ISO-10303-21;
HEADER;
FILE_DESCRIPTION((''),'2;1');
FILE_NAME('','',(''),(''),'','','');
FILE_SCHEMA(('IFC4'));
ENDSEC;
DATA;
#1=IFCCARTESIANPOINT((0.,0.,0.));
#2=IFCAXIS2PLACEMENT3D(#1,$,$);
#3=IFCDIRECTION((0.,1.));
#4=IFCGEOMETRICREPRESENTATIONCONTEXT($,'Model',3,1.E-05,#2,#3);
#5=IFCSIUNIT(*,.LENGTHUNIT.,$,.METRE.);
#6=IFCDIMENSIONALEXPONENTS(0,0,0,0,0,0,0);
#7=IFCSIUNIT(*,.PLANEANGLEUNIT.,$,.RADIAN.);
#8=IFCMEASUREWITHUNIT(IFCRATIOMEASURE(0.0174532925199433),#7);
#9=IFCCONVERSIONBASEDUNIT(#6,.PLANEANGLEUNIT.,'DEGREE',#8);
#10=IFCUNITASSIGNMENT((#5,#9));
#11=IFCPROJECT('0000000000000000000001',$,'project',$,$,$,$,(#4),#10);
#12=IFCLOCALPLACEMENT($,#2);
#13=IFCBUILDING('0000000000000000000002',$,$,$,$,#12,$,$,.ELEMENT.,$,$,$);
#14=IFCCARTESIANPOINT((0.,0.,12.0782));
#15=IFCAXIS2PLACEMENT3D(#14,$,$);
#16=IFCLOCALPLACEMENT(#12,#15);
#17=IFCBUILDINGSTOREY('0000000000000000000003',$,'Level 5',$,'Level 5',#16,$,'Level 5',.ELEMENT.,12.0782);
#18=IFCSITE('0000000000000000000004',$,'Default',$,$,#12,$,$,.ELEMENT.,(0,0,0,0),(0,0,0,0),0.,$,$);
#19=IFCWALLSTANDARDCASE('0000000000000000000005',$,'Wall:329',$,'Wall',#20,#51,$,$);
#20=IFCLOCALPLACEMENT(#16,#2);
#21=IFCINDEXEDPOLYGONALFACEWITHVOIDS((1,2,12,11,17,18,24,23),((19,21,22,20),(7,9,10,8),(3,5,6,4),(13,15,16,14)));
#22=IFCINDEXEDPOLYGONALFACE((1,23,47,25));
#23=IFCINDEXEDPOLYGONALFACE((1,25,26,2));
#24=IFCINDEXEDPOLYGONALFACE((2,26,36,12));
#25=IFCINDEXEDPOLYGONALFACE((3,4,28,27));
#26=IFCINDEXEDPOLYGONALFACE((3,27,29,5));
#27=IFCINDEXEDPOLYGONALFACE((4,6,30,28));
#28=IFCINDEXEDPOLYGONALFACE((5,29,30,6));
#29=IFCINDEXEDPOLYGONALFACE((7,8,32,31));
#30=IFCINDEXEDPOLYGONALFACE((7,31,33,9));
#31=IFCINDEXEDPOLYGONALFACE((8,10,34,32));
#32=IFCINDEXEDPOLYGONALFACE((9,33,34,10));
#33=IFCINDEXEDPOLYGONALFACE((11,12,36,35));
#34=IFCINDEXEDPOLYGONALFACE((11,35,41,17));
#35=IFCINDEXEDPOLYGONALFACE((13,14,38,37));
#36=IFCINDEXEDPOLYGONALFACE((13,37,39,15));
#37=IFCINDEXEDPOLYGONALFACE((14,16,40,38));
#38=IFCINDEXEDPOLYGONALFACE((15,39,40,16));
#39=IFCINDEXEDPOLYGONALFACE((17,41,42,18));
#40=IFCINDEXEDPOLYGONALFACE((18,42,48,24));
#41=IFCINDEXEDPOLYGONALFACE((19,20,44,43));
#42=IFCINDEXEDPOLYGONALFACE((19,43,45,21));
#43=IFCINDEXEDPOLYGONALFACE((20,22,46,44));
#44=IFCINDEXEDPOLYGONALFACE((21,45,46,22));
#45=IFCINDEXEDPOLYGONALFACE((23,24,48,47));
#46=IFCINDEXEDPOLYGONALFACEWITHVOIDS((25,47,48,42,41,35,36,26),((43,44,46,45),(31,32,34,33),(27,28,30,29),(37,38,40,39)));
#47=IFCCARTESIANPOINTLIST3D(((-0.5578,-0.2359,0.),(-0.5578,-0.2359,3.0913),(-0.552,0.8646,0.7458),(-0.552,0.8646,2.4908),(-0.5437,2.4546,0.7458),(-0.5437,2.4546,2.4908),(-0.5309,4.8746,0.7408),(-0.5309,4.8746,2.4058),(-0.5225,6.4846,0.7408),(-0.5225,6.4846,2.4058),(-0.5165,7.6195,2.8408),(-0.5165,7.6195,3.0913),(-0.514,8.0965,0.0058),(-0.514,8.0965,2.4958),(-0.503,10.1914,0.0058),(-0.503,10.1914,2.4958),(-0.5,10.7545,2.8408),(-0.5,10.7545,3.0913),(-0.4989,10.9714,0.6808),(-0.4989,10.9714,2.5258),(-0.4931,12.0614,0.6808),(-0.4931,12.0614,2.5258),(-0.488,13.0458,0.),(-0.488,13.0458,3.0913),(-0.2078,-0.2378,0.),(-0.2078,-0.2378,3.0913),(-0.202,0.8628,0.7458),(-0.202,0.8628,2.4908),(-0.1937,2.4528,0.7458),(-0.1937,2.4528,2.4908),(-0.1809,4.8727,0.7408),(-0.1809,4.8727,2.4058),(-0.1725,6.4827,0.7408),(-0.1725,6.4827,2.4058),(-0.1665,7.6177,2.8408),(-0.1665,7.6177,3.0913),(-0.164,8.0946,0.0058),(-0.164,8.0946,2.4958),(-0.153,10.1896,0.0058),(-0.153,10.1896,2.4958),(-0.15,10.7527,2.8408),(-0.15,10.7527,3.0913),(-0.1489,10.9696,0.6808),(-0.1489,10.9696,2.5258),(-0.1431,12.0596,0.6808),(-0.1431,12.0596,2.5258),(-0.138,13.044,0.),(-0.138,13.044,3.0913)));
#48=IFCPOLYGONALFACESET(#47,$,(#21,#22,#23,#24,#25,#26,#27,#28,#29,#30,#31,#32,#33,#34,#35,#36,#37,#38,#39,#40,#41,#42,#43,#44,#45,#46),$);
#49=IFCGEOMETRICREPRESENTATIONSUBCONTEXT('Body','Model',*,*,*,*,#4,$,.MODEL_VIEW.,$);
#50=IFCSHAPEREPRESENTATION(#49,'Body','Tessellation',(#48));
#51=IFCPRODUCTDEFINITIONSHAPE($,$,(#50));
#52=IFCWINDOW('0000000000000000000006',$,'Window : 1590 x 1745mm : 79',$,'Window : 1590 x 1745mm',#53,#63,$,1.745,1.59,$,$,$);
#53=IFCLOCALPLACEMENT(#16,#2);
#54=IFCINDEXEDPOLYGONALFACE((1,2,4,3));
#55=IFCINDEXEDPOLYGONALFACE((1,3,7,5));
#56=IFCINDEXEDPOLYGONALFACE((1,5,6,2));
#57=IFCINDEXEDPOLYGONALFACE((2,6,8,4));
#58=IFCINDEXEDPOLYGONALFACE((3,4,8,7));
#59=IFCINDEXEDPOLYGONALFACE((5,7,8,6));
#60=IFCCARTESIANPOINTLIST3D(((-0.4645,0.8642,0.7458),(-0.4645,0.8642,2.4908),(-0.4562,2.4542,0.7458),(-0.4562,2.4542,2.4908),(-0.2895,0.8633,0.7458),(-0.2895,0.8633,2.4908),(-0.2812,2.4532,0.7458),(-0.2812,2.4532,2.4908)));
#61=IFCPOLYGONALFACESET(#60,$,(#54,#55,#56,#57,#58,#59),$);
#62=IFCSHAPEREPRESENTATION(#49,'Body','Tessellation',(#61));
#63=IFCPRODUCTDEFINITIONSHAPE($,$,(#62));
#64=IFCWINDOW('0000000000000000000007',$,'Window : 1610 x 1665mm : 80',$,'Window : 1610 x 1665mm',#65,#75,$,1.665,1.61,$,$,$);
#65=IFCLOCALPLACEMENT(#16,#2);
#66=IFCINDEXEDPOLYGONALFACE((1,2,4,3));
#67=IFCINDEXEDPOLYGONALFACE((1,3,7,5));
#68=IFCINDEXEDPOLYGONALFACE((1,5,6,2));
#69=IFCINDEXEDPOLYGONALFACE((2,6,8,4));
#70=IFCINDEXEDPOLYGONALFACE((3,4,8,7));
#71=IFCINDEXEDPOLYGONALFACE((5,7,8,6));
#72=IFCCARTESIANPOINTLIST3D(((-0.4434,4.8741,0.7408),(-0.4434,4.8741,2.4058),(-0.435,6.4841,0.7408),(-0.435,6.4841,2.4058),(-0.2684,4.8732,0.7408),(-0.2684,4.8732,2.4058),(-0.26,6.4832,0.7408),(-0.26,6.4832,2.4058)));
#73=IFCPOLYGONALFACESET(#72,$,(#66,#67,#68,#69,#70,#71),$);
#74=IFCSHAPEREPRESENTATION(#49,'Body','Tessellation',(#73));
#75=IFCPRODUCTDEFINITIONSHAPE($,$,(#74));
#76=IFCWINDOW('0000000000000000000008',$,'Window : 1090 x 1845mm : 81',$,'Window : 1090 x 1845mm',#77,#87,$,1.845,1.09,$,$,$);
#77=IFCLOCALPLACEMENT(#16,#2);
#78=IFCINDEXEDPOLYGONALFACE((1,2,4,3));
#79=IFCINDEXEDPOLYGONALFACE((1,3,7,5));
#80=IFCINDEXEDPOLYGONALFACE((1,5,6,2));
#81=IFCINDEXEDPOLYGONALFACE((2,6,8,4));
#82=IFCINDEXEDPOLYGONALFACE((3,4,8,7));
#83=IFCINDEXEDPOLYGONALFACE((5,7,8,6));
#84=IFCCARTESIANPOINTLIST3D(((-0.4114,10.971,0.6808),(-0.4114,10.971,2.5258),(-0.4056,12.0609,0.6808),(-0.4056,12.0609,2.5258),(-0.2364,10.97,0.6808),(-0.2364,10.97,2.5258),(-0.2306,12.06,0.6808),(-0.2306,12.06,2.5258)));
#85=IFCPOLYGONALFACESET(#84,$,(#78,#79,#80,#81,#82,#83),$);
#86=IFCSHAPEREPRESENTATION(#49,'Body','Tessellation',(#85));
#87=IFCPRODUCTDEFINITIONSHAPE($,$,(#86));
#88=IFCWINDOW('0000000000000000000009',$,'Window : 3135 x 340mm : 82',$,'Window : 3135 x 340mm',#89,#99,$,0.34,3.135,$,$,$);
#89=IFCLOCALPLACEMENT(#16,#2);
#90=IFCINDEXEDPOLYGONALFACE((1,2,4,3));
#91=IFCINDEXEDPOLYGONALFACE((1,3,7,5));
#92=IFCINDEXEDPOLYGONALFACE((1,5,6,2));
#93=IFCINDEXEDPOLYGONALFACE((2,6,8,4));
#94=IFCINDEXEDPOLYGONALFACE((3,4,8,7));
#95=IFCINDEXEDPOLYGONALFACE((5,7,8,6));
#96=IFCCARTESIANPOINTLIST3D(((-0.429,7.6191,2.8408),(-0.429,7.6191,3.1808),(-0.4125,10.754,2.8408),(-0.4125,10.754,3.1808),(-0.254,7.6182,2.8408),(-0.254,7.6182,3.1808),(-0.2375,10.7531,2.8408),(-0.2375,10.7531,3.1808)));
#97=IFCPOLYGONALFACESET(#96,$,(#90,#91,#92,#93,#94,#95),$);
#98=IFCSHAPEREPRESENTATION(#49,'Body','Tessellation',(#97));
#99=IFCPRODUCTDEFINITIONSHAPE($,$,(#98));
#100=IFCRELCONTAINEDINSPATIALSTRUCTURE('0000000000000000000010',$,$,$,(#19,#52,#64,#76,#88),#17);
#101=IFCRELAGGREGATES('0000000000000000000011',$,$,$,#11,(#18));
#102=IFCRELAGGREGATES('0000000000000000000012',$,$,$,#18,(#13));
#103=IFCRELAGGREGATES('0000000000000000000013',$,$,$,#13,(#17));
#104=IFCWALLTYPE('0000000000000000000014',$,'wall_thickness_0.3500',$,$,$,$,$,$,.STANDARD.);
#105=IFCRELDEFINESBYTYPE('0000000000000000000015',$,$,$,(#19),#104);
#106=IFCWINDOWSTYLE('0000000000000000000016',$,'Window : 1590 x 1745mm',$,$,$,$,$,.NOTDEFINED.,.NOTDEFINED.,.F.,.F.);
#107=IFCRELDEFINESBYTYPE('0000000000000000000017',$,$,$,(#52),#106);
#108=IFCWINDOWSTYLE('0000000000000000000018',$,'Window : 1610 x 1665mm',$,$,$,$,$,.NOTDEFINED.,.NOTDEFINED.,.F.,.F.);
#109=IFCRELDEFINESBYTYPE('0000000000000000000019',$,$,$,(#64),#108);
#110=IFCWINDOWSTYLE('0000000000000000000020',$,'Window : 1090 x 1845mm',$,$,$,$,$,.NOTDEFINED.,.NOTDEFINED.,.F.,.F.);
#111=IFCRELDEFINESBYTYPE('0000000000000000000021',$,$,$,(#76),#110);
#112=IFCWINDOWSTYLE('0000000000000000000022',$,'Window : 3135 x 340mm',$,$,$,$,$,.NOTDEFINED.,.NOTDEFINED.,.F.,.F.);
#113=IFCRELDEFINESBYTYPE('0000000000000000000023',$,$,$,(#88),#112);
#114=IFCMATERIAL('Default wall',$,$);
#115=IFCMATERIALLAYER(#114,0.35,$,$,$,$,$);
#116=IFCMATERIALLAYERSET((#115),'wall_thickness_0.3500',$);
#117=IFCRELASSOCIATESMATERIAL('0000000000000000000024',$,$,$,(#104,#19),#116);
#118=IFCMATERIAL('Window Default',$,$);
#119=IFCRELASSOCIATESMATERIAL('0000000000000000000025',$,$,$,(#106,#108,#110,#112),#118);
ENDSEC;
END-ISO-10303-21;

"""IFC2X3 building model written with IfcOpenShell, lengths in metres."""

from ifc_helpers import new_model, entity, si_unit, converted_unit, direction, frame, frame_2d, origin, origin_2d_with_axis, place, context, subcontext, project, spatial, polyline, rectangle, outline, extrude, clip, halfspace, source, transform, mapped, material, layer, layer_set, layer_usage, type_object, type_shapes, element, fill, save


model = new_model("IFC2X3")

# Units and contexts
model_context = context("Model", 3, precision=1e-05, world=origin(), true_north=direction((0.0, 1.0)))
body_context = subcontext(model_context, "Body", "Model", "MODEL_VIEW")
ifc_project = project(units=[si_unit("LENGTHUNIT", "METRE"), converted_unit("PLANEANGLEUNIT", "DEGREE", entity("IfcRatioMeasure", 0.0174532925199433), si_unit("PLANEANGLEUNIT", "RADIAN"), dimensions=[0, 0, 0, 0, 0, 0, 0])], contexts=[model_context])

# Site, building, storey
placement_1 = place(None, origin())
site = spatial("IfcSite", under=ifc_project, at=placement_1, Name="Default", CompositionType="ELEMENT", RefLatitude=(0, 0, 0, 0), RefLongitude=(0, 0, 0, 0), RefElevation=0.0)
building = spatial("IfcBuilding", under=site, at=placement_1, CompositionType="ELEMENT")
storey_placement = place(placement_1, frame((0.0, 0.0, 12.0782)))
storey = spatial("IfcBuildingStorey", under=building, at=storey_placement, Name="Level 5", ObjectType="Level 5", LongName="Level 5", CompositionType="ELEMENT", Elevation=12.0782)

# Wall, openings, windows
ifc_material_1 = material(Name="Default wall")
ifc_layer_1 = layer(ifc_material_1, 0.35)
ifc_layer_set_1 = layer_set([ifc_layer_1], Name="wall_thickness_0.3500")
ifc_layer_usage_1 = layer_usage(ifc_layer_set_1, "AXIS2", "POSITIVE", -0.175)
wall_type_1 = type_object("IfcWallType", Name="wall_thickness_0.3500", PredefinedType="STANDARD", material=ifc_layer_set_1)
wall_1_placement = place(storey_placement, frame((-0.313, 13.0449, 0.0), z_axis=(0.0, 0.0, 1.0), x_axis=(-0.005258, -0.999986, 0.0)))
wall_1 = element("IfcWallStandardCase", 1, at=wall_1_placement, inside=storey, type_object=wall_type_1, material=ifc_layer_usage_1, Name="Wall:329", ObjectType="Wall", context=body_context, shape_type="Clipping", body=[
    clip(extrude(outline(polyline([(13.2819, -0.175), (13.2819, 0.175), (0.0, 0.175), (0.0, -0.175), (13.2819, -0.175)])), origin(), (0.0, 0.0, 1.0), 3.0913), halfspace(frame((-62.7971, -1.2439, 4.0083), z_axis=(0.000635, -0.389903, 0.920856), x_axis=(0.000711, 0.920855, 0.389905)), False)),
])
opening_1_placement = place(wall_1_placement, frame((2.8544, -0.175, 0.0058)))
element("IfcOpeningElement", 2, at=opening_1_placement, cuts=wall_1, ObjectType="Opening", context=body_context, shape_type="SweptSolid", body=[
    extrude(rectangle(XDim=2.095, YDim=2.49, at=frame_2d((1.245, 1.0475), x_axis=(0.0, 1.0))), frame((0.0, 0.0, 0.0), z_axis=(0.0, 1.0, 0.0), x_axis=(0.0, 0.0, 1.0)), (0.0, 0.0, 1.0), 0.35),
])
opening_2_placement = place(wall_1_placement, frame((10.5914, -0.175, 0.7458)))
opening_2 = element("IfcOpeningElement", 3, at=opening_2_placement, cuts=wall_1, ObjectType="Opening", context=body_context, shape_type="SweptSolid", body=[
    extrude(rectangle(XDim=1.59, YDim=1.745, at=frame_2d((0.8725, 0.795), x_axis=(0.0, 1.0))), frame((0.0, 0.0, 0.0), z_axis=(0.0, 1.0, 0.0), x_axis=(0.0, 0.0, 1.0)), (0.0, 0.0, 1.0), 0.35),
])
opening_3_placement = place(wall_1_placement, frame((6.5614, -0.175, 0.7408)))
opening_3 = element("IfcOpeningElement", 4, at=opening_3_placement, cuts=wall_1, ObjectType="Opening", context=body_context, shape_type="SweptSolid", body=[
    extrude(rectangle(XDim=1.61, YDim=1.665, at=frame_2d((0.8325, 0.805), x_axis=(0.0, 1.0))), frame((0.0, 0.0, 0.0), z_axis=(0.0, 1.0, 0.0), x_axis=(0.0, 0.0, 1.0)), (0.0, 0.0, 1.0), 0.35),
])
opening_4_placement = place(wall_1_placement, frame((0.9844, -0.175, 0.6808)))
opening_4 = element("IfcOpeningElement", 5, at=opening_4_placement, cuts=wall_1, ObjectType="Opening", context=body_context, shape_type="SweptSolid", body=[
    extrude(rectangle(XDim=1.09, YDim=1.845, at=frame_2d((0.9225, 0.545), x_axis=(0.0, 1.0))), frame((0.0, 0.0, 0.0), z_axis=(0.0, 1.0, 0.0), x_axis=(0.0, 0.0, 1.0)), (0.0, 0.0, 1.0), 0.35),
])
opening_5_placement = place(wall_1_placement, frame((2.2914, -0.175, 2.8408)))
opening_5 = element("IfcOpeningElement", 6, at=opening_5_placement, cuts=wall_1, ObjectType="Opening", context=body_context, shape_type="SweptSolid", body=[
    extrude(rectangle(XDim=3.135, YDim=0.34, at=frame_2d((0.17, 1.5675), x_axis=(0.0, 1.0))), frame((0.0, 0.0, 0.0), z_axis=(0.0, 1.0, 0.0), x_axis=(0.0, 0.0, 1.0)), (0.0, 0.0, 1.0), 0.35),
])
ifc_material_2 = material(Name="Window Default")
window_style_1 = type_object("IfcWindowStyle", Name="Window : 1590 x 1745mm", ConstructionType="NOTDEFINED", OperationType="NOTDEFINED", ParameterTakesPrecedence=False, Sizeable=False, material=ifc_material_2)
shared_shape_1 = source(origin(), body_context, "Body", "SweptSolid", [
    extrude(rectangle(XDim=0.175, YDim=1.59, at=origin_2d_with_axis()), frame((0.795, 0.175, 0.0), z_axis=(0.0, 0.0, 1.0), x_axis=(0.0, 1.0, 0.0)), (0.0, 0.0, 1.0), 1.745),
])
type_shapes(window_style_1, [shared_shape_1])
window_1_placement = place(opening_2_placement, origin())
window_1 = element("IfcWindow", 7, at=window_1_placement, inside=storey, type_object=window_style_1, Name="Window : 1590 x 1745mm : 79", ObjectType="Window : 1590 x 1745mm", OverallHeight=1.745, OverallWidth=1.59, context=body_context, shape_type="MappedRepresentation", body=[
    mapped(shared_shape_1, transform((0.0, 0.0, 0.0), scale=1.0)),
])
fill(opening_2, window_1)
window_style_2 = type_object("IfcWindowStyle", Name="Window : 1610 x 1665mm", ConstructionType="NOTDEFINED", OperationType="NOTDEFINED", ParameterTakesPrecedence=False, Sizeable=False, material=ifc_material_2)
shared_shape_2 = source(origin(), body_context, "Body", "SweptSolid", [
    extrude(rectangle(XDim=0.175, YDim=1.61, at=origin_2d_with_axis()), frame((0.805, 0.175, 0.0), z_axis=(0.0, 0.0, 1.0), x_axis=(0.0, 1.0, 0.0)), (0.0, 0.0, 1.0), 1.665),
])
type_shapes(window_style_2, [shared_shape_2])
window_2_placement = place(opening_3_placement, origin())
window_2 = element("IfcWindow", 8, at=window_2_placement, inside=storey, type_object=window_style_2, Name="Window : 1610 x 1665mm : 80", ObjectType="Window : 1610 x 1665mm", OverallHeight=1.665, OverallWidth=1.61, context=body_context, shape_type="MappedRepresentation", body=[
    mapped(shared_shape_2, transform((0.0, 0.0, 0.0), scale=1.0)),
])
fill(opening_3, window_2)
window_style_3 = type_object("IfcWindowStyle", Name="Window : 1090 x 1845mm", ConstructionType="NOTDEFINED", OperationType="NOTDEFINED", ParameterTakesPrecedence=False, Sizeable=False, material=ifc_material_2)
shared_shape_3 = source(origin(), body_context, "Body", "SweptSolid", [
    extrude(rectangle(XDim=0.175, YDim=1.09, at=origin_2d_with_axis()), frame((0.545, 0.175, 0.0), z_axis=(0.0, 0.0, 1.0), x_axis=(0.0, 1.0, 0.0)), (0.0, 0.0, 1.0), 1.845),
])
type_shapes(window_style_3, [shared_shape_3])
window_3_placement = place(opening_4_placement, origin())
window_3 = element("IfcWindow", 9, at=window_3_placement, inside=storey, type_object=window_style_3, Name="Window : 1090 x 1845mm : 81", ObjectType="Window : 1090 x 1845mm", OverallHeight=1.845, OverallWidth=1.09, context=body_context, shape_type="MappedRepresentation", body=[
    mapped(shared_shape_3, transform((0.0, 0.0, 0.0), scale=1.0)),
])
fill(opening_4, window_3)
window_style_4 = type_object("IfcWindowStyle", Name="Window : 3135 x 340mm", ConstructionType="NOTDEFINED", OperationType="NOTDEFINED", ParameterTakesPrecedence=False, Sizeable=False, material=ifc_material_2)
shared_shape_4 = source(origin(), body_context, "Body", "SweptSolid", [
    extrude(rectangle(XDim=0.175, YDim=3.135, at=origin_2d_with_axis()), frame((1.5675, 0.175, 0.0), z_axis=(0.0, 0.0, 1.0), x_axis=(0.0, 1.0, 0.0)), (0.0, 0.0, 1.0), 0.34),
])
type_shapes(window_style_4, [shared_shape_4])
window_4_placement = place(opening_5_placement, origin())
window_4 = element("IfcWindow", 10, at=window_4_placement, inside=storey, type_object=window_style_4, Name="Window : 3135 x 340mm : 82", ObjectType="Window : 3135 x 340mm", OverallHeight=0.34, OverallWidth=3.135, context=body_context, shape_type="MappedRepresentation", body=[
    mapped(shared_shape_4, transform((0.0, 0.0, 0.0), scale=1.0)),
])
fill(opening_5, window_4)

save(model, "model.ifc")
